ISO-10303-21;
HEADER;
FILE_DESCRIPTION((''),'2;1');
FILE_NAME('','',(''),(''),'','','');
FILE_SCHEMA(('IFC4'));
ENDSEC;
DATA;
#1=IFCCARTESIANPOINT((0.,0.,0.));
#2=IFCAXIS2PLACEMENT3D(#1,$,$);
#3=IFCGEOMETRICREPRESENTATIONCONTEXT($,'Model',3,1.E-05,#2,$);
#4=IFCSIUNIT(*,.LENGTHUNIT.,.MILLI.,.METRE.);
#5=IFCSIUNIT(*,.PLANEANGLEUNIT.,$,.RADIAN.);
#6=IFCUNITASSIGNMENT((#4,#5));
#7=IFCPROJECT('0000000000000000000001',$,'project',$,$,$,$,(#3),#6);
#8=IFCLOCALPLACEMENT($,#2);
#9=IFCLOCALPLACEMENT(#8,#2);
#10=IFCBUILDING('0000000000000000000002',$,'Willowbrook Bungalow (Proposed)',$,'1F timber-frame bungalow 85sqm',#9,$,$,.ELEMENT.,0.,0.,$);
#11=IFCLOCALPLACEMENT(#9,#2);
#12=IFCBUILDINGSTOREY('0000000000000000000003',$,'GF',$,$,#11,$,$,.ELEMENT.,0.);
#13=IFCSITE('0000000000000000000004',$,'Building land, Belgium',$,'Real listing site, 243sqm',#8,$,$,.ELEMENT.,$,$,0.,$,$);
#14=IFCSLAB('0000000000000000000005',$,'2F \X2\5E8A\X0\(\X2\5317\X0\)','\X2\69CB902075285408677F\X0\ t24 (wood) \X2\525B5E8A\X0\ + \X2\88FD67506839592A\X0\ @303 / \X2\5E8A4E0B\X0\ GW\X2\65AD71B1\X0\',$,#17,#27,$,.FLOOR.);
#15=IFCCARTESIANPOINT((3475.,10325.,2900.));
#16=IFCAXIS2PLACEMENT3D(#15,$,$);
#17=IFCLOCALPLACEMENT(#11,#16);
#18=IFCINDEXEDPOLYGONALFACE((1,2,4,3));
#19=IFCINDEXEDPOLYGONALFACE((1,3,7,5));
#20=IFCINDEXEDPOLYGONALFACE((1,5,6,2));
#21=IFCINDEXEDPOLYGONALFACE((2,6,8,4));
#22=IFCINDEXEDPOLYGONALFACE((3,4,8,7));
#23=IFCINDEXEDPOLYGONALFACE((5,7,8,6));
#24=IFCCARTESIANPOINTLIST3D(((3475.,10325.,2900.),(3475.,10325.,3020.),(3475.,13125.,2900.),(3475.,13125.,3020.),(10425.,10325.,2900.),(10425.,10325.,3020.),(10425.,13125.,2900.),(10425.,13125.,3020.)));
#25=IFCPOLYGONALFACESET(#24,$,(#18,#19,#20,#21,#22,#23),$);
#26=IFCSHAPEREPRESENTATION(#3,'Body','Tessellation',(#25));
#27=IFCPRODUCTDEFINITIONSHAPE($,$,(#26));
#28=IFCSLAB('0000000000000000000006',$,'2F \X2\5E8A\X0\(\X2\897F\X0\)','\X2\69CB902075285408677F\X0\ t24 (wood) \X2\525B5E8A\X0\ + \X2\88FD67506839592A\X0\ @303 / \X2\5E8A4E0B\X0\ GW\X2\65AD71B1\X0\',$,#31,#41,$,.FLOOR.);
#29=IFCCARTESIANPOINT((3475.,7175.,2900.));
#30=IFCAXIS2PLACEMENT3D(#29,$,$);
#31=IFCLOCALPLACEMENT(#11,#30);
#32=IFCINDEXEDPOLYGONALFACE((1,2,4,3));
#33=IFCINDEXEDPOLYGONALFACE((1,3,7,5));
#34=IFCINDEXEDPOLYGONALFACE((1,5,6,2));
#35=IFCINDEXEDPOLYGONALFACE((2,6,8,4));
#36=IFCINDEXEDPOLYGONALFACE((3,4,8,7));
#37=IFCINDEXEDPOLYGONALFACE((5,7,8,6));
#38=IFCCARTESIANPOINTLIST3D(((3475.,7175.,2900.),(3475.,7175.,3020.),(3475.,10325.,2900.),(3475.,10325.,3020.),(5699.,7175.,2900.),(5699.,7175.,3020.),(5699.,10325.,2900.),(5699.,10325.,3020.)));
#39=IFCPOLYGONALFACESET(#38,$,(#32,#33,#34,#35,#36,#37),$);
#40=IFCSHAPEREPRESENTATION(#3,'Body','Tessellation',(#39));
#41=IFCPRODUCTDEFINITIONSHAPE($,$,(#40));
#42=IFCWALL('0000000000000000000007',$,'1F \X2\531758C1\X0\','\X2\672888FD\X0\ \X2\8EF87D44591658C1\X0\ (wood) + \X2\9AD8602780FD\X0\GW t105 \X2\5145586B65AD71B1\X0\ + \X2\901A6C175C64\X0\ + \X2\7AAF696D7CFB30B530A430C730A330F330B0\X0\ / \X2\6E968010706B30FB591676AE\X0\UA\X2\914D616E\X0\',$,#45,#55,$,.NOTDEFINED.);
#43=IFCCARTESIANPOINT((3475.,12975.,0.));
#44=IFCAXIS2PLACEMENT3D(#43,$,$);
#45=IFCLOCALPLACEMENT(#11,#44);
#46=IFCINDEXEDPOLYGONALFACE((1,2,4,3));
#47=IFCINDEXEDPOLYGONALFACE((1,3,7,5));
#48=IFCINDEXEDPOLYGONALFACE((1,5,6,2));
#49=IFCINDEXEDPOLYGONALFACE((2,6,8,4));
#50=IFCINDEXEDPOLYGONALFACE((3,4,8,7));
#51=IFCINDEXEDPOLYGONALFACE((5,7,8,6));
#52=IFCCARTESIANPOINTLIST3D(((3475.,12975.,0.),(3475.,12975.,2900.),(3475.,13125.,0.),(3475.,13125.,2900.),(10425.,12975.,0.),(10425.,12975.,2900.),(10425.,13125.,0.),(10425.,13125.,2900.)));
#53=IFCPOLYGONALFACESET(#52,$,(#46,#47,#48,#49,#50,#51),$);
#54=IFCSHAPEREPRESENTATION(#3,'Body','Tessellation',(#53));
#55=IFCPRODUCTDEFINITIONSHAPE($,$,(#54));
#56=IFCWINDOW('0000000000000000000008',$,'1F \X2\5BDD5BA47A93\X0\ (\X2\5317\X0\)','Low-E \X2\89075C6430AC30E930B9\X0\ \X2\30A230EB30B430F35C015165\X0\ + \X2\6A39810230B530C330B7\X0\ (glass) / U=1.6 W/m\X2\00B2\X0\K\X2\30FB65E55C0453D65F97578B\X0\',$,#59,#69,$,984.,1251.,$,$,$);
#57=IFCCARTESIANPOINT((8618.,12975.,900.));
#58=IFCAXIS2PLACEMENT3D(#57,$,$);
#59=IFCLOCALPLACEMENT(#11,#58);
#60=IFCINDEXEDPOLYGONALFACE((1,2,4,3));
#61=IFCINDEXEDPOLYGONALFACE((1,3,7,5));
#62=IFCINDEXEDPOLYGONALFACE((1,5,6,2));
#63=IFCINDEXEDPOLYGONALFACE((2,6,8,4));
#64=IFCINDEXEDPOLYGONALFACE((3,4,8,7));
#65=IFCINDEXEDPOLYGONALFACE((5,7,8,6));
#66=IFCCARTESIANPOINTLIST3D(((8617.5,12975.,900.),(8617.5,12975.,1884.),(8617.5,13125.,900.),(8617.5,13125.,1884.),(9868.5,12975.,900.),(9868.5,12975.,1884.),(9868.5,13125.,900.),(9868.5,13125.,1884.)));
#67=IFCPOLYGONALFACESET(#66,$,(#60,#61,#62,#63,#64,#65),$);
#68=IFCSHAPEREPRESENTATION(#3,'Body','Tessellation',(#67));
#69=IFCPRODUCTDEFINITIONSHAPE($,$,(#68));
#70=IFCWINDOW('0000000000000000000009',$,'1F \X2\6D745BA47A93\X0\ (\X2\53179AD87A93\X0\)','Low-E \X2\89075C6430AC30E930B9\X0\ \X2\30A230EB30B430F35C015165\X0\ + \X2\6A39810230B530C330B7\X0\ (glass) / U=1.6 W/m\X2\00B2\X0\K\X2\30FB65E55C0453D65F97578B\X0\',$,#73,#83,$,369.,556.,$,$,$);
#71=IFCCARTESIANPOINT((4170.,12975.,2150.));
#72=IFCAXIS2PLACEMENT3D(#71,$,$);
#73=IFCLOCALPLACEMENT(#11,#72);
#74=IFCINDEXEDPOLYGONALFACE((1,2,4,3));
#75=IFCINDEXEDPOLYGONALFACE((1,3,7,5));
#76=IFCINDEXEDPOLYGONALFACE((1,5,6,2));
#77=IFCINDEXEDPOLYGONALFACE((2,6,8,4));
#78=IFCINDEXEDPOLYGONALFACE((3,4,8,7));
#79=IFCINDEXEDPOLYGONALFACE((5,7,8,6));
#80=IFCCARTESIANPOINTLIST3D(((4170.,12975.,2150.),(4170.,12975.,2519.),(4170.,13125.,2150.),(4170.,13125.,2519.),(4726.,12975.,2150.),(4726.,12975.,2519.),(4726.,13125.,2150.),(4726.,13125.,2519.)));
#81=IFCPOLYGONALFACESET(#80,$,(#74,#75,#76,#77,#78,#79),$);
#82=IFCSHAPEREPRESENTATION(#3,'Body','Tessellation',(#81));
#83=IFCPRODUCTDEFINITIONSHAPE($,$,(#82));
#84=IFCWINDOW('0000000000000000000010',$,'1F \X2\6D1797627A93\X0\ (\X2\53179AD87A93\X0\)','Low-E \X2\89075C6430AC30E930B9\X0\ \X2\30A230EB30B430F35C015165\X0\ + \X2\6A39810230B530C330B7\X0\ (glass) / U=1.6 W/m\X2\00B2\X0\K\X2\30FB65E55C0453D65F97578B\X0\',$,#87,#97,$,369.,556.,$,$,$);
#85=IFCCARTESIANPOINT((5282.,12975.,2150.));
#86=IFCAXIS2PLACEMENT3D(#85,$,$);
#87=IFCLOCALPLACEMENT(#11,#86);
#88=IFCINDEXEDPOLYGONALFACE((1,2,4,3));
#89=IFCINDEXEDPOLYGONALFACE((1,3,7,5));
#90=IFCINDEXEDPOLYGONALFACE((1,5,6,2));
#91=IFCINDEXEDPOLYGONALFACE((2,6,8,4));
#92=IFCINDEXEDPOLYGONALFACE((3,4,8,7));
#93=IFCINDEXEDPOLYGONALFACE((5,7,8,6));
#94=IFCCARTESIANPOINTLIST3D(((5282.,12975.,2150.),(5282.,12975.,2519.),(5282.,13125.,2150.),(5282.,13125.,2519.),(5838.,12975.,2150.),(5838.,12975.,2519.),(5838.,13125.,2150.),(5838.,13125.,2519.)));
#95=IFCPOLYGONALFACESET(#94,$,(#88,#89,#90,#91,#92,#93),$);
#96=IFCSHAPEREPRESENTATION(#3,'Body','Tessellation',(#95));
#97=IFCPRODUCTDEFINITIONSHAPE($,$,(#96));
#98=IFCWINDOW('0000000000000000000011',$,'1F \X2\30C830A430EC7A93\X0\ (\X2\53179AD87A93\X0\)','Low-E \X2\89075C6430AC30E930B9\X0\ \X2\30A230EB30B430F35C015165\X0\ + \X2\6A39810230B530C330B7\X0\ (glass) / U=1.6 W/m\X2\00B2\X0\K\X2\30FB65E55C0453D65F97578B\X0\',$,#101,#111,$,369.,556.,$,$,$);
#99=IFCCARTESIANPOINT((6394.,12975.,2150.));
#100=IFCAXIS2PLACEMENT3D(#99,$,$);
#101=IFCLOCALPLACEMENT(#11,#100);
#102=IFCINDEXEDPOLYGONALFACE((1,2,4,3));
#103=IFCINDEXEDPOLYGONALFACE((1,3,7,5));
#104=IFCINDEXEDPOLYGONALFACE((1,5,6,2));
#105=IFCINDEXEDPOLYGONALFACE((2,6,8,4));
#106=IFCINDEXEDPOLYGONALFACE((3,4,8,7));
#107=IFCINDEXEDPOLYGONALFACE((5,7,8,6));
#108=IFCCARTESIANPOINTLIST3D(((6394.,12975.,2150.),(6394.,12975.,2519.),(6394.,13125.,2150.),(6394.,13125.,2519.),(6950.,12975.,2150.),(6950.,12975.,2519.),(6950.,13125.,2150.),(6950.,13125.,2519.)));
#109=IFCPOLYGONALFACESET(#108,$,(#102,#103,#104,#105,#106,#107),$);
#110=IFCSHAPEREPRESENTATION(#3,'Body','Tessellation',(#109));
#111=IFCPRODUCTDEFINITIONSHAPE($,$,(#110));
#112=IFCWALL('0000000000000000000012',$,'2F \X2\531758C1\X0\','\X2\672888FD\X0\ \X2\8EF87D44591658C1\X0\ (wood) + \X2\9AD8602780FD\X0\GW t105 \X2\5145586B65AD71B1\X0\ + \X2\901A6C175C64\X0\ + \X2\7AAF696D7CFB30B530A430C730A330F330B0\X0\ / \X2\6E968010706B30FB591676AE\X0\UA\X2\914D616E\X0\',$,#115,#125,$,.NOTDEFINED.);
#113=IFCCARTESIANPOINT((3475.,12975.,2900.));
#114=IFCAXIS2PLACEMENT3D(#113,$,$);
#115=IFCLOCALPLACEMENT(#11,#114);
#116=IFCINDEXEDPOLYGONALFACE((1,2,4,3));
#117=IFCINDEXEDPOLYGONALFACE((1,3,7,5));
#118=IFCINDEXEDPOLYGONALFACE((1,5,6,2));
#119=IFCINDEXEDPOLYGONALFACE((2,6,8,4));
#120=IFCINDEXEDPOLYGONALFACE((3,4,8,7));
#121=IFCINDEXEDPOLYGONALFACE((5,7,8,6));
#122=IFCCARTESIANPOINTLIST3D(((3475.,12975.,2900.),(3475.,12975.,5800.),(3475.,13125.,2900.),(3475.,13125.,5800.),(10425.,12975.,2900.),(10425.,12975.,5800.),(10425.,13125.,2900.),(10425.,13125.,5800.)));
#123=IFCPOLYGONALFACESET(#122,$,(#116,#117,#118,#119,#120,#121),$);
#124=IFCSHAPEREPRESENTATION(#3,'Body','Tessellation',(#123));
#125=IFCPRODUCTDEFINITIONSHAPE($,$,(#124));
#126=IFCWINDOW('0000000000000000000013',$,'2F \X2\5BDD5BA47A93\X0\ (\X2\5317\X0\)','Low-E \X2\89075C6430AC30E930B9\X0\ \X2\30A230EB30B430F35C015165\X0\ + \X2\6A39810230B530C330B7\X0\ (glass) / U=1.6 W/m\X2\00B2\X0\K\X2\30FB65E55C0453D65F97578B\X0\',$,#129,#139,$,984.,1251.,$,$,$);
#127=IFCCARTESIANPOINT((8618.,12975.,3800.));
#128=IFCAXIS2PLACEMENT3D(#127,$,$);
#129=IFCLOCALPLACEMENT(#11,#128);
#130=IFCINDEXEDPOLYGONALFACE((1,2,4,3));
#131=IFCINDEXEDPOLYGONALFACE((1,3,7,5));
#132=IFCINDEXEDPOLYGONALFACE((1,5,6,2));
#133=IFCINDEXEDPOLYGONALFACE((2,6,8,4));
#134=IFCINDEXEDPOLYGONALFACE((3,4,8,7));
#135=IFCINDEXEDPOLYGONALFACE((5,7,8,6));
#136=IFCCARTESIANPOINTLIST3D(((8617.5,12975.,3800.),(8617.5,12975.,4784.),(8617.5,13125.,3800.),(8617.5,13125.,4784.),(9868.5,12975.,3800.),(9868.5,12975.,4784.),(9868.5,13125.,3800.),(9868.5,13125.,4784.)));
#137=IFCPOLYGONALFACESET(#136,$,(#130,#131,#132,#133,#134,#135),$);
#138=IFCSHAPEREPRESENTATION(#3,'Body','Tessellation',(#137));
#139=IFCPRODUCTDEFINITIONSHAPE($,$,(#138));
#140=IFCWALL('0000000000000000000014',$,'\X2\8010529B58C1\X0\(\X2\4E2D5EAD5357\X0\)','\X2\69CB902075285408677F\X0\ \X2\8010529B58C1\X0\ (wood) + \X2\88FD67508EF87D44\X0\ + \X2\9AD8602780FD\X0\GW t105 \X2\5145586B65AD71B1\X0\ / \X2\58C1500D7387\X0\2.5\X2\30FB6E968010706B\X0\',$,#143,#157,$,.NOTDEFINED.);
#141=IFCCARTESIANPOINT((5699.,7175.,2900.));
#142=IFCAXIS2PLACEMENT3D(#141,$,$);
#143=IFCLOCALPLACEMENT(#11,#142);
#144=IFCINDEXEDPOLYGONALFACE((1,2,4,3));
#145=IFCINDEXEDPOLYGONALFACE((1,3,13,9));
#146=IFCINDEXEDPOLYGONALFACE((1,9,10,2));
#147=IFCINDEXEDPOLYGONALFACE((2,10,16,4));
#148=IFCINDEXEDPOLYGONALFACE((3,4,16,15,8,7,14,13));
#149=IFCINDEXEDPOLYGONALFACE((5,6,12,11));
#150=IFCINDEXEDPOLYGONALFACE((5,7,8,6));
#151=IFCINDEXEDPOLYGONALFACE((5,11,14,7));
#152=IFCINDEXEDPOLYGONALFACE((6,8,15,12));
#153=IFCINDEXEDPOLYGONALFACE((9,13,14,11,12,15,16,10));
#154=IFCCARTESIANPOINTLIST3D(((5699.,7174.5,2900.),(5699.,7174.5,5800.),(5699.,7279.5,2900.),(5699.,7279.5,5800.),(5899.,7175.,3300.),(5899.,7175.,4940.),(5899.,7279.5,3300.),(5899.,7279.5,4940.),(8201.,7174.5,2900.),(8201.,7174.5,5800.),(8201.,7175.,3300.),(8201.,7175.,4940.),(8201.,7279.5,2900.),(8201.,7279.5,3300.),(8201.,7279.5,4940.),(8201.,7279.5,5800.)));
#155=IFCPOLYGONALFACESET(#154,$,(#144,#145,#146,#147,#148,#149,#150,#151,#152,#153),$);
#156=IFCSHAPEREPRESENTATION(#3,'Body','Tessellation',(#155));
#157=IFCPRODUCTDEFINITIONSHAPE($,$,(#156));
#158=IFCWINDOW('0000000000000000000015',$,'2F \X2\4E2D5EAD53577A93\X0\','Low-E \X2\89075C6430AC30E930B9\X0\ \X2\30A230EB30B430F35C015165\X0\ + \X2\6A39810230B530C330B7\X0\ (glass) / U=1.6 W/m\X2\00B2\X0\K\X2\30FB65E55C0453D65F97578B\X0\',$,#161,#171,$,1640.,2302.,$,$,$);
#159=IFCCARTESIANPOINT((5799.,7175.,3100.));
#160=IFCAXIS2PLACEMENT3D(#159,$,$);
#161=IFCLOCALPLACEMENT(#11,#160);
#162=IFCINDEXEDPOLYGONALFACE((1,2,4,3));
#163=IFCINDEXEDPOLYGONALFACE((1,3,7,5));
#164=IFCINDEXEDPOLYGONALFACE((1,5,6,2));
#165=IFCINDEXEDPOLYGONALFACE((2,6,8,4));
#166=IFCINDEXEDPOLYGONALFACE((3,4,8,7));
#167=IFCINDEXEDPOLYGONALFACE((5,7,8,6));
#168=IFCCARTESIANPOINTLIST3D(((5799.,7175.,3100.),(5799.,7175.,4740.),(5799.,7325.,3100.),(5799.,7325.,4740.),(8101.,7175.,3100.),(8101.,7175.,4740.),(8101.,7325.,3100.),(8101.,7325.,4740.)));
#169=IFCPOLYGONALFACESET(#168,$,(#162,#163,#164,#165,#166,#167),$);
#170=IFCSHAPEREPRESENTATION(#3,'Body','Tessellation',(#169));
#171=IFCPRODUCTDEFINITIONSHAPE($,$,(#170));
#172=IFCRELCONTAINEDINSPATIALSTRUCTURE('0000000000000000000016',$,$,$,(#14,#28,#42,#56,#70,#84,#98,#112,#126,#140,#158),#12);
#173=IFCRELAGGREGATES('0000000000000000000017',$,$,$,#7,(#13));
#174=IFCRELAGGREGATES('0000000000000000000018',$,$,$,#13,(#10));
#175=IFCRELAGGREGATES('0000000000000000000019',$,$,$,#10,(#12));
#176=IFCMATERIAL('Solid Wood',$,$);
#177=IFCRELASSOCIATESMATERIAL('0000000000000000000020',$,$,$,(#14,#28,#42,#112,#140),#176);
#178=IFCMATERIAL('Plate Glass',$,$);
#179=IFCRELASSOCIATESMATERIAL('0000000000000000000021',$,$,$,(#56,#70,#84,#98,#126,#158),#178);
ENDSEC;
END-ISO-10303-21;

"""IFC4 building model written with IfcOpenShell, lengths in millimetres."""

from ifc_helpers import new_model, si_unit, frame, frame_2d, origin, place, context, project, spatial, rectangle, extrude, material, element, fill, save


model = new_model("IFC4")

# Units and contexts
model_context = context("Model", 3, precision=1e-05, world=origin())
ifc_project = project(units=[si_unit("LENGTHUNIT", "METRE", prefix="MILLI"), si_unit("PLANEANGLEUNIT", "RADIAN")], contexts=[model_context])

# Site, building, storey
site_placement = place(None, origin())
site = spatial("IfcSite", under=ifc_project, at=site_placement, Name="Building land, Belgium", ObjectType="Real listing site, 243sqm", CompositionType="ELEMENT", RefElevation=0.0)
building_placement = place(site_placement, origin())
building = spatial("IfcBuilding", under=site, at=building_placement, Name="Willowbrook Bungalow (Proposed)", ObjectType="1F timber-frame bungalow 85sqm", CompositionType="ELEMENT", ElevationOfRefHeight=0.0, ElevationOfTerrain=0.0)
storey_placement = place(building_placement, origin())
storey = spatial("IfcBuildingStorey", under=building, at=storey_placement, Name="GF", CompositionType="ELEMENT", Elevation=0.0)

# Slabs
ifc_material_1 = material(Name="Solid Wood")
slab_1_placement = place(storey_placement, frame((3475.0, 10325.0, 2900.0)))
element("IfcSlab", 1, at=slab_1_placement, inside=storey, material=ifc_material_1, Name="2F 床(北)", Description="構造用合板 t24 (wood) 剛床 + 製材根太 @303 / 床下 GW断熱", PredefinedType="FLOOR", context=model_context, shape_type="SweptSolid", body=[
    extrude(rectangle(XDim=6950.0, YDim=2800.0, at=frame_2d((3475.0, 1400.0))), frame((3475.0, 10325.0, 2900.0)), (0.0, 0.0, 1.0), 120.0),
])
slab_2_placement = place(storey_placement, frame((3475.0, 7175.0, 2900.0)))
element("IfcSlab", 2, at=slab_2_placement, inside=storey, material=ifc_material_1, Name="2F 床(西)", Description="構造用合板 t24 (wood) 剛床 + 製材根太 @303 / 床下 GW断熱", PredefinedType="FLOOR", context=model_context, shape_type="SweptSolid", body=[
    extrude(rectangle(XDim=2224.0, YDim=3150.0, at=frame_2d((1112.0, 1575.0))), frame((3475.0, 7175.0, 2900.0)), (0.0, 0.0, 1.0), 120.0),
])

# Wall, openings, windows
wall_1_placement = place(storey_placement, frame((3475.0, 12975.0, 0.0)))
wall_1 = element("IfcWall", 3, at=wall_1_placement, inside=storey, material=ifc_material_1, Name="1F 北壁", Description="木製 軸組外壁 (wood) + 高性能GW t105 充填断熱 + 通気層 + 窯業系サイディング / 準耐火・外皮UA配慮", PredefinedType="NOTDEFINED", context=model_context, shape_type="SweptSolid", body=[
    extrude(rectangle(XDim=6950.0, YDim=150.0, at=frame_2d((3475.0, 75.0))), frame((3475.0, 12975.0, 0.0)), (0.0, 0.0, 1.0), 2900.0),
])
opening_1_placement = place(storey_placement, frame((8618.0, 12975.0, 900.0)))
opening_1 = element("IfcOpeningElement", 4, at=opening_1_placement, cuts=wall_1, PredefinedType="NOTDEFINED", context=model_context, shape_type="SweptSolid", body=[
    extrude(rectangle(XDim=1251.0, YDim=150.0, at=frame_2d((625.0, 75.0))), frame((8618.0, 12975.0, 900.0)), (0.0, 0.0, 1.0), 984.0),
])
opening_2_placement = place(storey_placement, frame((4170.0, 12975.0, 2150.0)))
opening_2 = element("IfcOpeningElement", 5, at=opening_2_placement, cuts=wall_1, PredefinedType="NOTDEFINED", context=model_context, shape_type="SweptSolid", body=[
    extrude(rectangle(XDim=556.0, YDim=150.0, at=frame_2d((278.0, 75.0))), frame((4170.0, 12975.0, 2150.0)), (0.0, 0.0, 1.0), 369.0),
])
opening_3_placement = place(storey_placement, frame((5282.0, 12975.0, 2150.0)))
opening_3 = element("IfcOpeningElement", 6, at=opening_3_placement, cuts=wall_1, PredefinedType="NOTDEFINED", context=model_context, shape_type="SweptSolid", body=[
    extrude(rectangle(XDim=556.0, YDim=150.0, at=frame_2d((278.0, 75.0))), frame((5282.0, 12975.0, 2150.0)), (0.0, 0.0, 1.0), 369.0),
])
opening_4_placement = place(storey_placement, frame((6394.0, 12975.0, 2150.0)))
opening_4 = element("IfcOpeningElement", 7, at=opening_4_placement, cuts=wall_1, PredefinedType="NOTDEFINED", context=model_context, shape_type="SweptSolid", body=[
    extrude(rectangle(XDim=556.0, YDim=150.0, at=frame_2d((278.0, 75.0))), frame((6394.0, 12975.0, 2150.0)), (0.0, 0.0, 1.0), 369.0),
])
ifc_material_2 = material(Name="Plate Glass")
window_1_placement = place(storey_placement, frame((8618.0, 12975.0, 900.0)))
window_1 = element("IfcWindow", 8, at=window_1_placement, inside=storey, material=ifc_material_2, Name="1F 寝室窓 (北)", Description="Low-E 複層ガラス アルゴン封入 + 樹脂サッシ (glass) / U=1.6 W/m²K・日射取得型", OverallHeight=984.0, OverallWidth=1251.0, context=model_context, shape_type="SweptSolid", body=[
    extrude(rectangle(XDim=1251.0, YDim=150.0, at=frame_2d((625.0, 75.0))), frame((8618.0, 12975.0, 900.0)), (0.0, 0.0, 1.0), 984.0),
])
fill(opening_1, window_1)
window_2_placement = place(storey_placement, frame((4170.0, 12975.0, 2150.0)))
window_2 = element("IfcWindow", 9, at=window_2_placement, inside=storey, material=ifc_material_2, Name="1F 浴室窓 (北高窓)", Description="Low-E 複層ガラス アルゴン封入 + 樹脂サッシ (glass) / U=1.6 W/m²K・日射取得型", OverallHeight=369.0, OverallWidth=556.0, context=model_context, shape_type="SweptSolid", body=[
    extrude(rectangle(XDim=556.0, YDim=150.0, at=frame_2d((278.0, 75.0))), frame((4170.0, 12975.0, 2150.0)), (0.0, 0.0, 1.0), 369.0),
])
fill(opening_2, window_2)
window_3_placement = place(storey_placement, frame((5282.0, 12975.0, 2150.0)))
window_3 = element("IfcWindow", 10, at=window_3_placement, inside=storey, material=ifc_material_2, Name="1F 洗面窓 (北高窓)", Description="Low-E 複層ガラス アルゴン封入 + 樹脂サッシ (glass) / U=1.6 W/m²K・日射取得型", OverallHeight=369.0, OverallWidth=556.0, context=model_context, shape_type="SweptSolid", body=[
    extrude(rectangle(XDim=556.0, YDim=150.0, at=frame_2d((278.0, 75.0))), frame((5282.0, 12975.0, 2150.0)), (0.0, 0.0, 1.0), 369.0),
])
fill(opening_3, window_3)
window_4_placement = place(storey_placement, frame((6394.0, 12975.0, 2150.0)))
window_4 = element("IfcWindow", 11, at=window_4_placement, inside=storey, material=ifc_material_2, Name="1F トイレ窓 (北高窓)", Description="Low-E 複層ガラス アルゴン封入 + 樹脂サッシ (glass) / U=1.6 W/m²K・日射取得型", OverallHeight=369.0, OverallWidth=556.0, context=model_context, shape_type="SweptSolid", body=[
    extrude(rectangle(XDim=556.0, YDim=150.0, at=frame_2d((278.0, 75.0))), frame((6394.0, 12975.0, 2150.0)), (0.0, 0.0, 1.0), 369.0),
])
fill(opening_4, window_4)

# Walls, openings, windows
wall_2_placement = place(storey_placement, frame((3475.0, 12975.0, 2900.0)))
wall_2 = element("IfcWall", 12, at=wall_2_placement, inside=storey, material=ifc_material_1, Name="2F 北壁", Description="木製 軸組外壁 (wood) + 高性能GW t105 充填断熱 + 通気層 + 窯業系サイディング / 準耐火・外皮UA配慮", PredefinedType="NOTDEFINED", context=model_context, shape_type="SweptSolid", body=[
    extrude(rectangle(XDim=6950.0, YDim=150.0, at=frame_2d((3475.0, 75.0))), frame((3475.0, 12975.0, 2900.0)), (0.0, 0.0, 1.0), 2900.0),
])
opening_5_placement = place(storey_placement, frame((8618.0, 12975.0, 3800.0)))
opening_5 = element("IfcOpeningElement", 13, at=opening_5_placement, cuts=wall_2, PredefinedType="NOTDEFINED", context=model_context, shape_type="SweptSolid", body=[
    extrude(rectangle(XDim=1251.0, YDim=150.0, at=frame_2d((625.0, 75.0))), frame((8618.0, 12975.0, 3800.0)), (0.0, 0.0, 1.0), 984.0),
])
window_5_placement = place(storey_placement, frame((8618.0, 12975.0, 3800.0)))
window_5 = element("IfcWindow", 14, at=window_5_placement, inside=storey, material=ifc_material_2, Name="2F 寝室窓 (北)", Description="Low-E 複層ガラス アルゴン封入 + 樹脂サッシ (glass) / U=1.6 W/m²K・日射取得型", OverallHeight=984.0, OverallWidth=1251.0, context=model_context, shape_type="SweptSolid", body=[
    extrude(rectangle(XDim=1251.0, YDim=150.0, at=frame_2d((625.0, 75.0))), frame((8618.0, 12975.0, 3800.0)), (0.0, 0.0, 1.0), 984.0),
])
fill(opening_5, window_5)
wall_3_placement = place(storey_placement, frame((5699.0, 7175.0, 2900.0)))
wall_3 = element("IfcWall", 15, at=wall_3_placement, inside=storey, material=ifc_material_1, Name="耐力壁(中庭南)", Description="構造用合板 耐力壁 (wood) + 製材軸組 + 高性能GW t105 充填断熱 / 壁倍率2.5・準耐火", PredefinedType="NOTDEFINED", context=model_context, shape_type="SweptSolid", body=[
    extrude(rectangle(XDim=2502.0, YDim=105.0, at=frame_2d((1251.0, 52.0))), frame((5699.0, 7175.0, 2900.0)), (0.0, 0.0, 1.0), 2900.0),
])
opening_6_placement = place(storey_placement, frame((5799.0, 7175.0, 3100.0)))
opening_6 = element("IfcOpeningElement", 16, at=opening_6_placement, cuts=wall_3, PredefinedType="NOTDEFINED", context=model_context, shape_type="SweptSolid", body=[
    extrude(rectangle(XDim=2302.0, YDim=150.0, at=frame_2d((1151.0, 75.0))), frame((5799.0, 7175.0, 3100.0)), (0.0, 0.0, 1.0), 1640.0),
])
window_6_placement = place(storey_placement, frame((5799.0, 7175.0, 3100.0)))
window_6 = element("IfcWindow", 17, at=window_6_placement, inside=storey, material=ifc_material_2, Name="2F 中庭南窓", Description="Low-E 複層ガラス アルゴン封入 + 樹脂サッシ (glass) / U=1.6 W/m²K・日射取得型", OverallHeight=1640.0, OverallWidth=2302.0, context=model_context, shape_type="SweptSolid", body=[
    extrude(rectangle(XDim=2302.0, YDim=150.0, at=frame_2d((1151.0, 75.0))), frame((5799.0, 7175.0, 3100.0)), (0.0, 0.0, 1.0), 1640.0),
])
fill(opening_6, window_6)

save(model, "model.ifc")
